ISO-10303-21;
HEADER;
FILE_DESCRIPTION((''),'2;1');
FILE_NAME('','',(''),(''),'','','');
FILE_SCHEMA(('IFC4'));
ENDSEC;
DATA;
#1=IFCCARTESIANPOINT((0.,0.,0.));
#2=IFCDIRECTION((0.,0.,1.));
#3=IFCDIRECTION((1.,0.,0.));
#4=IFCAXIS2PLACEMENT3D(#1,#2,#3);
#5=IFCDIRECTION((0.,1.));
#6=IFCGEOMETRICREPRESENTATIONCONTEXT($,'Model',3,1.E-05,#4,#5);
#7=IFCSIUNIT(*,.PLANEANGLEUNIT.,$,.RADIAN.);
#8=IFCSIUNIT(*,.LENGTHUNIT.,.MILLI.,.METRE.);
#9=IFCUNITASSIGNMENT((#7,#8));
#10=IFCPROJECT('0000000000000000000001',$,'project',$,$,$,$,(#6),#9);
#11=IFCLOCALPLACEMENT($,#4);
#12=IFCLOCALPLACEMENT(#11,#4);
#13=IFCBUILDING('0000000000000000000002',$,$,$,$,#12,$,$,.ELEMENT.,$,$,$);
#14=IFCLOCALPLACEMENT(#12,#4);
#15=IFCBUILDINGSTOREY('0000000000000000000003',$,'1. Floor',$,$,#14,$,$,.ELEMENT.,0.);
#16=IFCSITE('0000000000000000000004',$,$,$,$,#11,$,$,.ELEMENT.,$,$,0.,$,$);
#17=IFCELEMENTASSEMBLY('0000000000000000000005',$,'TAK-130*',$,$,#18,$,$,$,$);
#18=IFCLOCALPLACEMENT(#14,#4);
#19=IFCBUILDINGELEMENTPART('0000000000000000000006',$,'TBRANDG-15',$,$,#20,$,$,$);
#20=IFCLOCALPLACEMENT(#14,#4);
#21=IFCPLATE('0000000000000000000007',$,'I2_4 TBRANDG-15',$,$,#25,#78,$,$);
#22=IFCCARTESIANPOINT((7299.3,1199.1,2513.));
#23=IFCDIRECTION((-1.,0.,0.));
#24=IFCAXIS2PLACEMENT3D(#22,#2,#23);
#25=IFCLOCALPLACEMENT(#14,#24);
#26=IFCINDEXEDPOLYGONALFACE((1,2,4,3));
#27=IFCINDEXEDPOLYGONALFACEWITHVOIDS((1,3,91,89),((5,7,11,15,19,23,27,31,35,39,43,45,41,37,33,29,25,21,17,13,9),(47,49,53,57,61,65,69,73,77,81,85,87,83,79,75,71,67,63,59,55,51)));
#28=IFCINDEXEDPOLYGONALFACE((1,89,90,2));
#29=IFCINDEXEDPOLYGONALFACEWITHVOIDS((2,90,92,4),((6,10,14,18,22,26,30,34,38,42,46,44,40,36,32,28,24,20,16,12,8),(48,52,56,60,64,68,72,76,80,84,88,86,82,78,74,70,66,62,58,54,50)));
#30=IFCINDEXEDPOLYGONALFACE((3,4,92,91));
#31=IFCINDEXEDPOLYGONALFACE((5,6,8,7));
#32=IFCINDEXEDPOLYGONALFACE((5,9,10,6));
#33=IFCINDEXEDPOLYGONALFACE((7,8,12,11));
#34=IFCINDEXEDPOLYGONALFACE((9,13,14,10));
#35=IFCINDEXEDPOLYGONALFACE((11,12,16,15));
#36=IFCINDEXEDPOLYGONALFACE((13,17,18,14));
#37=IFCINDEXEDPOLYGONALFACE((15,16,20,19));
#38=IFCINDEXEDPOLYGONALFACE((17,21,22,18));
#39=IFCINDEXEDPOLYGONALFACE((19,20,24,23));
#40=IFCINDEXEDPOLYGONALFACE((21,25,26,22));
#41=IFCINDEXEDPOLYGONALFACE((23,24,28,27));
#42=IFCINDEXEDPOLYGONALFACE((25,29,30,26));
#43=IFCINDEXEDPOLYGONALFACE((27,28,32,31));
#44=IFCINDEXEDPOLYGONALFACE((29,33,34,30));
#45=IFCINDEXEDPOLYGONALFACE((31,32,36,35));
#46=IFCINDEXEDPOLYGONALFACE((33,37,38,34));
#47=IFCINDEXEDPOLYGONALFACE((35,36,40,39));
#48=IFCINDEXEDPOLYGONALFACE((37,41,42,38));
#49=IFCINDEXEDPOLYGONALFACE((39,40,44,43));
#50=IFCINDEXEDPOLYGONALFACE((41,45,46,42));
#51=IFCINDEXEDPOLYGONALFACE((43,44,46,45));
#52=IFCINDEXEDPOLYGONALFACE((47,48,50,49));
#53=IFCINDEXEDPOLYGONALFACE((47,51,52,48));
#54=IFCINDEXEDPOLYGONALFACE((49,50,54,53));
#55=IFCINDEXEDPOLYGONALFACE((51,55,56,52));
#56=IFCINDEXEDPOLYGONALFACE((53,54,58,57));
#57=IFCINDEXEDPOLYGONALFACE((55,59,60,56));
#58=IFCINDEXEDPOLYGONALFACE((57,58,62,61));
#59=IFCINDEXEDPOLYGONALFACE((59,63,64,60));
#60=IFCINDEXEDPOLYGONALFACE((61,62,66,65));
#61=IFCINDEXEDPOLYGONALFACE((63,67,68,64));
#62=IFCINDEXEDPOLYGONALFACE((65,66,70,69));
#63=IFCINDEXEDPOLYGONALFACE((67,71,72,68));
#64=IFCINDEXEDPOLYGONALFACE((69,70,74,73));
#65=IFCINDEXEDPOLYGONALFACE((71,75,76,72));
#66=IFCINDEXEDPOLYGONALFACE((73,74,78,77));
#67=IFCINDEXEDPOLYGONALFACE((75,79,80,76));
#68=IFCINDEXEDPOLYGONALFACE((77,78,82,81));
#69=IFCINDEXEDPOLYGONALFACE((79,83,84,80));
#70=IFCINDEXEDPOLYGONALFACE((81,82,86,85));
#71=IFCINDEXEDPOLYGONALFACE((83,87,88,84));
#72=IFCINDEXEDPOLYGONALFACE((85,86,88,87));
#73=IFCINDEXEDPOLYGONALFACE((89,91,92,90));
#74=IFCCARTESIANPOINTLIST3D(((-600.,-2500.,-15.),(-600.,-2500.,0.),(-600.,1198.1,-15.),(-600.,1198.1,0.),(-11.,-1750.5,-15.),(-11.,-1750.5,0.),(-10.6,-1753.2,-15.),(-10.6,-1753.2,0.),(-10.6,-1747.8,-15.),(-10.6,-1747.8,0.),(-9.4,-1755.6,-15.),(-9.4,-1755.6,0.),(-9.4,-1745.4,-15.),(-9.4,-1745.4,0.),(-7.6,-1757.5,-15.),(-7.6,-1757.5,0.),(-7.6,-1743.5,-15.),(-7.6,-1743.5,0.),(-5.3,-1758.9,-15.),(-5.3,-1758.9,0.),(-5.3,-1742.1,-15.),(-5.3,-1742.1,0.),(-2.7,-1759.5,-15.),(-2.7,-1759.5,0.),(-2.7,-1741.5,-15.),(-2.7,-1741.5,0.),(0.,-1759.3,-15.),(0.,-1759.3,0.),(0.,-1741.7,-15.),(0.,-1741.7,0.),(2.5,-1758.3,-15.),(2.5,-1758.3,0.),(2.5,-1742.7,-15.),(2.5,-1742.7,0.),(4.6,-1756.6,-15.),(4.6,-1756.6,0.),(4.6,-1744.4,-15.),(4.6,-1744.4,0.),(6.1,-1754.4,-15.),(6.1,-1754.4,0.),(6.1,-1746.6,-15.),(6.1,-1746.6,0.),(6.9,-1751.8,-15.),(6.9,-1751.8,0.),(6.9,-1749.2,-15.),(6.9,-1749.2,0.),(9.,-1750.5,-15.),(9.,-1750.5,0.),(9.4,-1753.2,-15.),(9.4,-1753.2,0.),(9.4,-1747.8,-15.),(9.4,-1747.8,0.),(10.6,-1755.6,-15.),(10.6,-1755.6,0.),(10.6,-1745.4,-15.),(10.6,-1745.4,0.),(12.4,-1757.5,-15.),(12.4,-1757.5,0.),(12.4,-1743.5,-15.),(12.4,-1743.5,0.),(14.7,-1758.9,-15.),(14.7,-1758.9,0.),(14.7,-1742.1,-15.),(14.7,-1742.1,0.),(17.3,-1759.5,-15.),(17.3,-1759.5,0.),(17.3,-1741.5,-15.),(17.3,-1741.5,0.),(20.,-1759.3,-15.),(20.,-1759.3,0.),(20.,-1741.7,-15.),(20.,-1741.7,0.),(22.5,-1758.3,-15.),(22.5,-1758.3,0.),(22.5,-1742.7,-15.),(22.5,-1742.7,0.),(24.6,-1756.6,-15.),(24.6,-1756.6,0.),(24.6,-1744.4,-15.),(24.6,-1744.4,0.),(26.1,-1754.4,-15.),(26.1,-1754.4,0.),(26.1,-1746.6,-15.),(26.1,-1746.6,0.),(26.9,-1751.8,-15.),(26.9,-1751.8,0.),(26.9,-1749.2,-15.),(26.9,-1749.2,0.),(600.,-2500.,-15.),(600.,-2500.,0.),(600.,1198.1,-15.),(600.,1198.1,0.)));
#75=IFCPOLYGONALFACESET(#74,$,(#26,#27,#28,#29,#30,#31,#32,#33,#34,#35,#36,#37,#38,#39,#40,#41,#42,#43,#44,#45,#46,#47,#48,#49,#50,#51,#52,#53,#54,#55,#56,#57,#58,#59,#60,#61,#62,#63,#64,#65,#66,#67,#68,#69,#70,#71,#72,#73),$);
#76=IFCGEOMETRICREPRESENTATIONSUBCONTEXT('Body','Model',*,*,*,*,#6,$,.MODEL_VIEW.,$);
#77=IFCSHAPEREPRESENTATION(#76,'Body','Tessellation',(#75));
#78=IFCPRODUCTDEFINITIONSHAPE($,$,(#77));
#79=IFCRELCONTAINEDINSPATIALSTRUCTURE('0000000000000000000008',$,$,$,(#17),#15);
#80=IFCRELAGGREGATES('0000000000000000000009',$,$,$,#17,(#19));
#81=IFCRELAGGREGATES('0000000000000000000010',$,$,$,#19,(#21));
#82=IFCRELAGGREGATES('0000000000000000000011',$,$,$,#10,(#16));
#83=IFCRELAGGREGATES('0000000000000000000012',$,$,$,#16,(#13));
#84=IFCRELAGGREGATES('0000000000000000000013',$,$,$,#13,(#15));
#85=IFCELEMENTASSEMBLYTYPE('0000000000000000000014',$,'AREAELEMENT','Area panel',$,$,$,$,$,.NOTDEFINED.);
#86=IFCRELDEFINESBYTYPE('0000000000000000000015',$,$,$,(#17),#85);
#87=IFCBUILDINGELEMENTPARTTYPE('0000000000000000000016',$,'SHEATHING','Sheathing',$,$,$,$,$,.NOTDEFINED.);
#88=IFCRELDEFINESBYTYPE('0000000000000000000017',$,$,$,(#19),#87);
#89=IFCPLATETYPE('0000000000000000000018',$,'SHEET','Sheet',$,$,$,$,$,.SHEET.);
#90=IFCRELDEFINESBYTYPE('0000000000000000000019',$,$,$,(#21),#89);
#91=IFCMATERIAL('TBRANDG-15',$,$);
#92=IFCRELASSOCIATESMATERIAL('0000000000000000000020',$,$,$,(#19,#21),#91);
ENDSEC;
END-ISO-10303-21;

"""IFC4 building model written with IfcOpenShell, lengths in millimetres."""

from ifc_helpers import new_model, si_unit, direction, frame, origin_with_axes, origin_2d_with_axis, place, context, subcontext, project, spatial, rectangle, circle, extrude, boolean, material, type_object, element, aggregate, save


model = new_model("IFC4")

# Units and contexts
model_context = context("Model", 3, precision=1e-05, world=origin_with_axes(), true_north=direction((0.0, 1.0)))
body_context = subcontext(model_context, "Body", "Model", "MODEL_VIEW")
ifc_project = project(units=[si_unit("PLANEANGLEUNIT", "RADIAN"), si_unit("LENGTHUNIT", "METRE", prefix="MILLI")], contexts=[model_context])

# Site, building, storey
site_placement = place(None, origin_with_axes())
site = spatial("IfcSite", under=ifc_project, at=site_placement, CompositionType="ELEMENT", RefElevation=0.0)
building_placement = place(site_placement, origin_with_axes())
building = spatial("IfcBuilding", under=site, at=building_placement, CompositionType="ELEMENT")
storey_placement = place(building_placement, origin_with_axes())
storey = spatial("IfcBuildingStorey", under=building, at=storey_placement, Name="1. Floor", CompositionType="ELEMENT", Elevation=0.0)

# Element assembly
element_assembly_type_1 = type_object("IfcElementAssemblyType", Name="AREAELEMENT", Description="Area panel", PredefinedType="NOTDEFINED")
assembly_1_placement = place(storey_placement, origin_with_axes())
assembly_1 = element("IfcElementAssembly", 1, at=assembly_1_placement, inside=storey, type_object=element_assembly_type_1, Name="TAK-130*")

# Shared definitions
building_element_part_type_1 = type_object("IfcBuildingElementPartType", Name="SHEATHING", Description="Sheathing", PredefinedType="NOTDEFINED")
plate_type = type_object("IfcPlateType", Name="SHEET", Description="Sheet", PredefinedType="SHEET")

# Shared definitions
ifc_material_1 = material(Name="TBRANDG-15")

# Building element part
building_element_part_1_placement = place(storey_placement, origin_with_axes())
building_element_part_1 = element("IfcBuildingElementPart", 2, at=building_element_part_1_placement, type_object=building_element_part_type_1, material=ifc_material_1, Name="TBRANDG-15")
aggregate(assembly_1, [building_element_part_1])

# Plate
plate_1_placement = place(storey_placement, frame((7299.3, 1199.1, 2513.0), z_axis=(0.0, 0.0, 1.0), x_axis=(-1.0, 0.0, 0.0)))
plate_1 = element("IfcPlate", 3, at=plate_1_placement, type_object=plate_type, material=ifc_material_1, Name="I2_4 TBRANDG-15", context=body_context, shape_type="CSG", body=[
    boolean("DIFFERENCE", boolean("DIFFERENCE", boolean("DIFFERENCE", boolean("DIFFERENCE", boolean("DIFFERENCE", boolean("DIFFERENCE", boolean("DIFFERENCE", boolean("DIFFERENCE", extrude(rectangle(XDim=15.0, YDim=1200.0, at=origin_2d_with_axis()), frame((0.0, -2500.0, -7.5), z_axis=(0.0, 1.0, 0.0), x_axis=(0.0, 0.0, 1.0)), (0.0, 0.0, 1.0), 3698.1), extrude(circle(Radius=9.0, at=origin_2d_with_axis()), frame((18.0, -1750.5, 25.0), z_axis=(0.0, 0.0, 1.0), x_axis=(-1.0, 0.0, 0.0)), (0.0, 0.0, -1.0), 50.0)), extrude(circle(Radius=9.0, at=origin_2d_with_axis()), frame((-2.0, -1750.5, 25.0), z_axis=(0.0, 0.0, 1.0), x_axis=(-1.0, 0.0, 0.0)), (0.0, 0.0, -1.0), 50.0)), extrude(circle(Radius=9.0, at=origin_2d_with_axis()), frame((18.0, -1750.5, 25.0), z_axis=(0.0, 0.0, 1.0), x_axis=(-1.0, 0.0, 0.0)), (0.0, 0.0, -1.0), 50.0)), extrude(circle(Radius=9.0, at=origin_2d_with_axis()), frame((-2.0, -1750.5, 25.0), z_axis=(0.0, 0.0, 1.0), x_axis=(-1.0, 0.0, 0.0)), (0.0, 0.0, -1.0), 50.0)), extrude(circle(Radius=9.0, at=origin_2d_with_axis()), frame((18.0, -1750.5, 25.0), z_axis=(0.0, 0.0, 1.0), x_axis=(-1.0, 0.0, 0.0)), (0.0, 0.0, -1.0), 50.0)), extrude(circle(Radius=9.0, at=origin_2d_with_axis()), frame((-2.0, -1750.5, 25.0), z_axis=(0.0, 0.0, 1.0), x_axis=(-1.0, 0.0, 0.0)), (0.0, 0.0, -1.0), 50.0)), extrude(circle(Radius=9.0, at=origin_2d_with_axis()), frame((18.0, -1750.5, 25.0), z_axis=(0.0, 0.0, 1.0), x_axis=(-1.0, 0.0, 0.0)), (0.0, 0.0, -1.0), 50.0)), extrude(circle(Radius=9.0, at=origin_2d_with_axis()), frame((-2.0, -1750.5, 25.0), z_axis=(0.0, 0.0, 1.0), x_axis=(-1.0, 0.0, 0.0)), (0.0, 0.0, -1.0), 50.0)),
])
aggregate(building_element_part_1, [plate_1])

save(model, "model.ifc")
